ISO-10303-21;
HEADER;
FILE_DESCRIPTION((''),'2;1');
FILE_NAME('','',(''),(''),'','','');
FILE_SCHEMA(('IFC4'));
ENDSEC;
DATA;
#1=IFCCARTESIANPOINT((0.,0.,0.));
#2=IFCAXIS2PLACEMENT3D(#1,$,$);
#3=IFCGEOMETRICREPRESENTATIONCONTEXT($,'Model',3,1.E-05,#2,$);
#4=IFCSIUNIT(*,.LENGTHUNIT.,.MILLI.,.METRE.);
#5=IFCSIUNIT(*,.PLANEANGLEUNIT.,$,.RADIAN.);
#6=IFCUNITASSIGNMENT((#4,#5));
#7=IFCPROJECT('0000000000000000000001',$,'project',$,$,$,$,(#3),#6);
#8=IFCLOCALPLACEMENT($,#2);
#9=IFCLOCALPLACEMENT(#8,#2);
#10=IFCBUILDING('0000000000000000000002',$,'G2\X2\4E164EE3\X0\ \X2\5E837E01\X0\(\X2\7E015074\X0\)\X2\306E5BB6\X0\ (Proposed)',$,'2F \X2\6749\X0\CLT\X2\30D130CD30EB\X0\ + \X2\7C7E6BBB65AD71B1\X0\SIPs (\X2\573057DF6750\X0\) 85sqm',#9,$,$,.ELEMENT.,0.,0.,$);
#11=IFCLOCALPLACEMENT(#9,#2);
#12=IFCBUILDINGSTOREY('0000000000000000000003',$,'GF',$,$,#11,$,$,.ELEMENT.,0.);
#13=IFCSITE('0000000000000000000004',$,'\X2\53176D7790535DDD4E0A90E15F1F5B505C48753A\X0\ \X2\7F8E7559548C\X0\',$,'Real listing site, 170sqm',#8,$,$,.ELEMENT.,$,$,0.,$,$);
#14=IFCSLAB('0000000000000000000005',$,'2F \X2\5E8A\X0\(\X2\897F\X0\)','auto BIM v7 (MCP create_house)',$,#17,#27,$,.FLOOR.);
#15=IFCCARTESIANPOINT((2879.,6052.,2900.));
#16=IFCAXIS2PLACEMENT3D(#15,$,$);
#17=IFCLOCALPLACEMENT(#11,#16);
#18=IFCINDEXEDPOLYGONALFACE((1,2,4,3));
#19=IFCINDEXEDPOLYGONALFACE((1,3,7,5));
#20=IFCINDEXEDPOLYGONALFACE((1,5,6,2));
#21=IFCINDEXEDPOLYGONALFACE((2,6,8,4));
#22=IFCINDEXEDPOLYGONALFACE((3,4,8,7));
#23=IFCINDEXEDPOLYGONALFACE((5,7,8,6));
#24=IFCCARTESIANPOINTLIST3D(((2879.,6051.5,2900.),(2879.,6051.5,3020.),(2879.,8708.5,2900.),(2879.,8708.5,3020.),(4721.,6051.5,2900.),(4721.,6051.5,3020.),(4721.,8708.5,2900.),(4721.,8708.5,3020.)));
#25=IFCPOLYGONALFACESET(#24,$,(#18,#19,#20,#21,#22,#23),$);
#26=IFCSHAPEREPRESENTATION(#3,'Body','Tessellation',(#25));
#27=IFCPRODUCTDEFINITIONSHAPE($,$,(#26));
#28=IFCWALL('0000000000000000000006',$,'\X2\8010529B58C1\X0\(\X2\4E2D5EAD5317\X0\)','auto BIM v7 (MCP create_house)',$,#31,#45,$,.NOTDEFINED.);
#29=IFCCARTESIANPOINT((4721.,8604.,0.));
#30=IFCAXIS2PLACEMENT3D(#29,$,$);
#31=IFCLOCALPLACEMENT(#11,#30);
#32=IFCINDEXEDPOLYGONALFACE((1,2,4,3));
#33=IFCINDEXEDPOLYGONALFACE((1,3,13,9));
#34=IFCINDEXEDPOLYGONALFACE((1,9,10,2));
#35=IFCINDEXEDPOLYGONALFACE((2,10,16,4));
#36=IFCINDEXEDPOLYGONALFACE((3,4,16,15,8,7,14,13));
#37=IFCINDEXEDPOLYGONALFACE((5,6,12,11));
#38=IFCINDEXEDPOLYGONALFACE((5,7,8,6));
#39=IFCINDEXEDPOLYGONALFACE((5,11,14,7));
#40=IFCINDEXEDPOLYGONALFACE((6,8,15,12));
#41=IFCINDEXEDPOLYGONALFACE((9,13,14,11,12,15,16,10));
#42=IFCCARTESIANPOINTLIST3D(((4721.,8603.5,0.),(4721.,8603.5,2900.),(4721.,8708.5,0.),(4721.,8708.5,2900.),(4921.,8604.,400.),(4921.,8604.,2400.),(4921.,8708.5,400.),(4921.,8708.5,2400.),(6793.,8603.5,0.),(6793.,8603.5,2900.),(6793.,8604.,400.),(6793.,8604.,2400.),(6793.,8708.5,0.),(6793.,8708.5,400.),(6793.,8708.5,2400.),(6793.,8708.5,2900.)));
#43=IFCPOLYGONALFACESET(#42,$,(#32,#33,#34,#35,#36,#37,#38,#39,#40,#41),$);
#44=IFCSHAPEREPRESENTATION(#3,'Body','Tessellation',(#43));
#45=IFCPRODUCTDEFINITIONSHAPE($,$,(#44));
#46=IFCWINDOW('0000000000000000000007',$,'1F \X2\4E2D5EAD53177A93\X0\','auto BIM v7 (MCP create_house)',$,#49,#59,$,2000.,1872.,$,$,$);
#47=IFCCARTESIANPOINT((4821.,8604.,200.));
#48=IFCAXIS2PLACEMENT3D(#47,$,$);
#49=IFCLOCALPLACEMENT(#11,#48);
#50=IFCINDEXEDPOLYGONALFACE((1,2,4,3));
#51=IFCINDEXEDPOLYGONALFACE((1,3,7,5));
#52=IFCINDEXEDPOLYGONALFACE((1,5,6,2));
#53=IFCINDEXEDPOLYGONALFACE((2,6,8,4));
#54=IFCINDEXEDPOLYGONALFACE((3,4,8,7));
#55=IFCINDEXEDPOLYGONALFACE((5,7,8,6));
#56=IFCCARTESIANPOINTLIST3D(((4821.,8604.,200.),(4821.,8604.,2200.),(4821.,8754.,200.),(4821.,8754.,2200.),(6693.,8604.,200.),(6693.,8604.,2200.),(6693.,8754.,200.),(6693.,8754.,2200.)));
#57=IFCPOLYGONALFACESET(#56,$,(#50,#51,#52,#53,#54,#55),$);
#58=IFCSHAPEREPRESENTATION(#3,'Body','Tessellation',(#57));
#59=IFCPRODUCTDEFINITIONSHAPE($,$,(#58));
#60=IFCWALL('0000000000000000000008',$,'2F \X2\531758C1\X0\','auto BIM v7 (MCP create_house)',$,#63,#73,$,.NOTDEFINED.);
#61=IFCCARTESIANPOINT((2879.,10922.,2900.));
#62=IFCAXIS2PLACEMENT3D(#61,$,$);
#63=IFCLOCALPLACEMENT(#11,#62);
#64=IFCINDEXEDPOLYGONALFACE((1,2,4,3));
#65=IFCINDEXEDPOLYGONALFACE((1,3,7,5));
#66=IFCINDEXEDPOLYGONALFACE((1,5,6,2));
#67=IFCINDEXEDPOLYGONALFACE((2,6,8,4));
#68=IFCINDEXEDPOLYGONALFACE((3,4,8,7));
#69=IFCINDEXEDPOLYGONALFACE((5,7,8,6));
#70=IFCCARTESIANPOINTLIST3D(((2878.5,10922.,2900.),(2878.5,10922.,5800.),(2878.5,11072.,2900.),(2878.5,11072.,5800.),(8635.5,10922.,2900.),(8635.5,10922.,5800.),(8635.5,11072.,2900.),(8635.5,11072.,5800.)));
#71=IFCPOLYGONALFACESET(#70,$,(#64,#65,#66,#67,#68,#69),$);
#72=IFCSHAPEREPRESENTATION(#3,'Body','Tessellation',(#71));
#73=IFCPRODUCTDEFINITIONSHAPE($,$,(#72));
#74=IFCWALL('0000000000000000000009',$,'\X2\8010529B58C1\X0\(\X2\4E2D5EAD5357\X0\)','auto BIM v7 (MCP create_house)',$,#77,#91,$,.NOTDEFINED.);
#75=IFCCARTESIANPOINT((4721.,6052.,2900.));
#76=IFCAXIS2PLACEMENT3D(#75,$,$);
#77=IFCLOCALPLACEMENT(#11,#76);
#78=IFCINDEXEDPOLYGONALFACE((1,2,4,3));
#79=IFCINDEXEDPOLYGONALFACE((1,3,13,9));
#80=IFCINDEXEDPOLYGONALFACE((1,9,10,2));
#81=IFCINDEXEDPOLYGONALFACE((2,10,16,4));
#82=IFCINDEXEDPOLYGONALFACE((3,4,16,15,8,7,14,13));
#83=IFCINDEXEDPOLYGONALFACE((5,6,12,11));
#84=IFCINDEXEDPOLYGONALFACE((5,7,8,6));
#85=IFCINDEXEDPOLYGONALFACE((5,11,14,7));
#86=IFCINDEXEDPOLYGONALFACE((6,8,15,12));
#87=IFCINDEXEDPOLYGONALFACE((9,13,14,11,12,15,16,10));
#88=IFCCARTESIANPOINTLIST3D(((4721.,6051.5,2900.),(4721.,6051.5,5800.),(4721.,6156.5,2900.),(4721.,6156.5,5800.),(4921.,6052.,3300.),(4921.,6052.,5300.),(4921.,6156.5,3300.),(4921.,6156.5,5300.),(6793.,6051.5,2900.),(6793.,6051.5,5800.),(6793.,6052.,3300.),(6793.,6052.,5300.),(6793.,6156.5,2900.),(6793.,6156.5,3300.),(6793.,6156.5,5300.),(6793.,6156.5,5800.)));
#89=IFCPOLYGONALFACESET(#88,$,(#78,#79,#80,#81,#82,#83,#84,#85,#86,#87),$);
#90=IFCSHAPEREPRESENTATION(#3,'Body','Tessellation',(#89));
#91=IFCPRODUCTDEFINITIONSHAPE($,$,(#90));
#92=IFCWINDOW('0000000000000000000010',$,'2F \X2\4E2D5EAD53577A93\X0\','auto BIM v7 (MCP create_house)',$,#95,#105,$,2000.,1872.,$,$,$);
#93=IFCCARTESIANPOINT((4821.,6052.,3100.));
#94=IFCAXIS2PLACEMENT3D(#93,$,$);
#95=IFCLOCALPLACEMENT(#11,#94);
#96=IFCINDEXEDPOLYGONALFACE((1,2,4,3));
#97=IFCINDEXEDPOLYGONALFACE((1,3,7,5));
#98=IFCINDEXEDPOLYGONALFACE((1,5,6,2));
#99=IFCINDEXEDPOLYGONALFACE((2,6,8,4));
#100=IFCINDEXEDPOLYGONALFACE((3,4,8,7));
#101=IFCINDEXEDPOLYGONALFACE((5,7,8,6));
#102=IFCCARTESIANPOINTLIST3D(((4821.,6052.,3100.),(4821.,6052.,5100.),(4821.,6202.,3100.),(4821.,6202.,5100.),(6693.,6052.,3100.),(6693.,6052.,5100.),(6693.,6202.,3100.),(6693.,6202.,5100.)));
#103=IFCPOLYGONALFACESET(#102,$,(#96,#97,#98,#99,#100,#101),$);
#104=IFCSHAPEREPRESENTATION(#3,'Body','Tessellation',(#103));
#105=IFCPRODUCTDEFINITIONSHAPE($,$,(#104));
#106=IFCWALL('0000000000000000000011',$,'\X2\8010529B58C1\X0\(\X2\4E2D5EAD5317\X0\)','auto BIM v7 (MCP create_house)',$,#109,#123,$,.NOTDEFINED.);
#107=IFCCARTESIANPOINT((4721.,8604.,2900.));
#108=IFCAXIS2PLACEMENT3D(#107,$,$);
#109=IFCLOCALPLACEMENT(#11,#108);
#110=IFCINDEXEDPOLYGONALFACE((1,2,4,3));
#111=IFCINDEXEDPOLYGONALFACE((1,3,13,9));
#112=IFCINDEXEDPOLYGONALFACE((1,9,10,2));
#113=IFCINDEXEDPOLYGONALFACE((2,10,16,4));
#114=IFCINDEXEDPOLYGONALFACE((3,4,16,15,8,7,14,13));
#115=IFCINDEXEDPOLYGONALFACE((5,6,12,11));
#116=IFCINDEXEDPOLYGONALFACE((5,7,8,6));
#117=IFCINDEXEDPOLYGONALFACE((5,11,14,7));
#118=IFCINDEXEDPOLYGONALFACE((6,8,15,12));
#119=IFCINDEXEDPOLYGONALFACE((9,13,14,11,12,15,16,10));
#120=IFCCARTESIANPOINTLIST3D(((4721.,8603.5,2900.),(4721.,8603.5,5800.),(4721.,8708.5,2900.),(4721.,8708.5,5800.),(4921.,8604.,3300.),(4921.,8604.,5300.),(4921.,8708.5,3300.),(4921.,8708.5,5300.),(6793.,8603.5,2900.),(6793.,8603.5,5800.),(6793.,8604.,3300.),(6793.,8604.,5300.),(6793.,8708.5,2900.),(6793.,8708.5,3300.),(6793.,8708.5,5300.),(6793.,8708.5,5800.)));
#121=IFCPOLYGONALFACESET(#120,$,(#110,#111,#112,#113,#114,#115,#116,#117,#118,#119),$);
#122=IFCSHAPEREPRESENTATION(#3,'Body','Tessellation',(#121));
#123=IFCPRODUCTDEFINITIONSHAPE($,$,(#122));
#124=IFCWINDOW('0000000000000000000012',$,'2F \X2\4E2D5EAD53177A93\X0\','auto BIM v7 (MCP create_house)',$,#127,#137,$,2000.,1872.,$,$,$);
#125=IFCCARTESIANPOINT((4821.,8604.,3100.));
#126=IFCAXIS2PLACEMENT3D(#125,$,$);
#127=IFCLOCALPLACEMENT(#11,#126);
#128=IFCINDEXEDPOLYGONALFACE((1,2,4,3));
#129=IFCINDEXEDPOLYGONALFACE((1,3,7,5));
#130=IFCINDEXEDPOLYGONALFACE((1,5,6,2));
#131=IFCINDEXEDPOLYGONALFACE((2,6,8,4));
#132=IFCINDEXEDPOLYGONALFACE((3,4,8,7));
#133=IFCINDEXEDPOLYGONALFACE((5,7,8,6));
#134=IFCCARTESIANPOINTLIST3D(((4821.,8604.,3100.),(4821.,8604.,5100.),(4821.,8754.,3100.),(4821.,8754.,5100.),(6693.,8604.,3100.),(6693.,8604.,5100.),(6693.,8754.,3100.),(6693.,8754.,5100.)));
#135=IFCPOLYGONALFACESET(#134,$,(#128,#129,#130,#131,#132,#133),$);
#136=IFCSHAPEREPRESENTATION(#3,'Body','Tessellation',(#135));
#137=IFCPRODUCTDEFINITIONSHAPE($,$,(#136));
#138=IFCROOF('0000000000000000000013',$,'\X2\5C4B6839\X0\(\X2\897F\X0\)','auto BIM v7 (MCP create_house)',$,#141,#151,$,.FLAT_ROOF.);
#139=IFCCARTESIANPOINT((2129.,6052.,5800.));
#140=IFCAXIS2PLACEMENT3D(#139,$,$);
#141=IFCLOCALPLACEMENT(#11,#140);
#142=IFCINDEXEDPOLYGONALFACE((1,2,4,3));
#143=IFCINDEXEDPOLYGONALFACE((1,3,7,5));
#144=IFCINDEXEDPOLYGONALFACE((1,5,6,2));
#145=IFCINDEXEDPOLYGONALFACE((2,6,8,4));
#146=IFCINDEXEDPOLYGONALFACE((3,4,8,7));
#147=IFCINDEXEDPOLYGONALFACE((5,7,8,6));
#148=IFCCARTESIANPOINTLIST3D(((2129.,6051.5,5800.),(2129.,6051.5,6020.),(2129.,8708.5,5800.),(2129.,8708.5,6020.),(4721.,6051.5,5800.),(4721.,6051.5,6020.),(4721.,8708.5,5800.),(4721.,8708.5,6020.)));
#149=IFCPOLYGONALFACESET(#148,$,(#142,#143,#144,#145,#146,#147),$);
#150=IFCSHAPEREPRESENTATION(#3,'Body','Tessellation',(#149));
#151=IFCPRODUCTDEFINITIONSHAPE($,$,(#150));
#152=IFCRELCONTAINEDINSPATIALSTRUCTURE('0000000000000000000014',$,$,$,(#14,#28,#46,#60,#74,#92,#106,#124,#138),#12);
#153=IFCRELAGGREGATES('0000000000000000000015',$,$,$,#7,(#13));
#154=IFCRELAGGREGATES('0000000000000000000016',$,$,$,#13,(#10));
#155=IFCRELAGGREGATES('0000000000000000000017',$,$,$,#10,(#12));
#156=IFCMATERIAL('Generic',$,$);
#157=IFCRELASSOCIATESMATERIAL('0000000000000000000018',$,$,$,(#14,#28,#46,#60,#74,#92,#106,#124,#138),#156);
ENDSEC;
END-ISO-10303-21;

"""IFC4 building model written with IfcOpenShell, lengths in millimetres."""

from ifc_helpers import new_model, si_unit, frame, frame_2d, origin, place, context, project, spatial, rectangle, extrude, material, element, fill, save


model = new_model("IFC4")

# Units and contexts
model_context = context("Model", 3, precision=1e-05, world=origin())
ifc_project = project(units=[si_unit("LENGTHUNIT", "METRE", prefix="MILLI"), si_unit("PLANEANGLEUNIT", "RADIAN")], contexts=[model_context])

# Site, building, storey
site_placement = place(None, origin())
site = spatial("IfcSite", under=ifc_project, at=site_placement, Name="北海道川上郡弟子屈町 美留和", ObjectType="Real listing site, 170sqm", CompositionType="ELEMENT", RefElevation=0.0)
building_placement = place(site_placement, origin())
building = spatial("IfcBuilding", under=site, at=building_placement, Name="G2世代 広縁(縁側)の家 (Proposed)", ObjectType="2F 杉CLTパネル + 籾殻断熱SIPs (地域材) 85sqm", CompositionType="ELEMENT", ElevationOfRefHeight=0.0, ElevationOfTerrain=0.0)
storey_placement = place(building_placement, origin())
storey = spatial("IfcBuildingStorey", under=building, at=storey_placement, Name="GF", CompositionType="ELEMENT", Elevation=0.0)

# Slab
ifc_material = material(Name="Generic")
slab_1_placement = place(storey_placement, frame((2879.0, 6052.0, 2900.0)))
element("IfcSlab", 1, at=slab_1_placement, inside=storey, material=ifc_material, Name="2F 床(西)", Description="auto BIM v7 (MCP create_house)", PredefinedType="FLOOR", context=model_context, shape_type="SweptSolid", body=[
    extrude(rectangle(XDim=1842.0, YDim=2657.0, at=frame_2d((921.0, 1328.0))), frame((2879.0, 6052.0, 2900.0)), (0.0, 0.0, 1.0), 120.0),
])

# Wall, opening, window
wall_1_placement = place(storey_placement, frame((4721.0, 8604.0, 0.0)))
wall_1 = element("IfcWall", 2, at=wall_1_placement, inside=storey, material=ifc_material, Name="耐力壁(中庭北)", Description="auto BIM v7 (MCP create_house)", PredefinedType="NOTDEFINED", context=model_context, shape_type="SweptSolid", body=[
    extrude(rectangle(XDim=2072.0, YDim=105.0, at=frame_2d((1036.0, 52.0))), frame((4721.0, 8604.0, 0.0)), (0.0, 0.0, 1.0), 2900.0),
])
opening_1_placement = place(storey_placement, frame((4821.0, 8604.0, 200.0)))
opening_1 = element("IfcOpeningElement", 3, at=opening_1_placement, cuts=wall_1, PredefinedType="NOTDEFINED", context=model_context, shape_type="SweptSolid", body=[
    extrude(rectangle(XDim=1872.0, YDim=150.0, at=frame_2d((936.0, 75.0))), frame((4821.0, 8604.0, 200.0)), (0.0, 0.0, 1.0), 2000.0),
])
window_1_placement = place(storey_placement, frame((4821.0, 8604.0, 200.0)))
window_1 = element("IfcWindow", 4, at=window_1_placement, inside=storey, material=ifc_material, Name="1F 中庭北窓", Description="auto BIM v7 (MCP create_house)", OverallHeight=2000.0, OverallWidth=1872.0, context=model_context, shape_type="SweptSolid", body=[
    extrude(rectangle(XDim=1872.0, YDim=150.0, at=frame_2d((936.0, 75.0))), frame((4821.0, 8604.0, 200.0)), (0.0, 0.0, 1.0), 2000.0),
])
fill(opening_1, window_1)

# Wall
wall_2_placement = place(storey_placement, frame((2879.0, 10922.0, 2900.0)))
element("IfcWall", 5, at=wall_2_placement, inside=storey, material=ifc_material, Name="2F 北壁", Description="auto BIM v7 (MCP create_house)", PredefinedType="NOTDEFINED", context=model_context, shape_type="SweptSolid", body=[
    extrude(rectangle(XDim=5757.0, YDim=150.0, at=frame_2d((2878.0, 75.0))), frame((2879.0, 10922.0, 2900.0)), (0.0, 0.0, 1.0), 2900.0),
])

# Walls, openings, windows
wall_3_placement = place(storey_placement, frame((4721.0, 6052.0, 2900.0)))
wall_3 = element("IfcWall", 6, at=wall_3_placement, inside=storey, material=ifc_material, Name="耐力壁(中庭南)", Description="auto BIM v7 (MCP create_house)", PredefinedType="NOTDEFINED", context=model_context, shape_type="SweptSolid", body=[
    extrude(rectangle(XDim=2072.0, YDim=105.0, at=frame_2d((1036.0, 52.0))), frame((4721.0, 6052.0, 2900.0)), (0.0, 0.0, 1.0), 2900.0),
])
opening_2_placement = place(storey_placement, frame((4821.0, 6052.0, 3100.0)))
opening_2 = element("IfcOpeningElement", 7, at=opening_2_placement, cuts=wall_3, PredefinedType="NOTDEFINED", context=model_context, shape_type="SweptSolid", body=[
    extrude(rectangle(XDim=1872.0, YDim=150.0, at=frame_2d((936.0, 75.0))), frame((4821.0, 6052.0, 3100.0)), (0.0, 0.0, 1.0), 2000.0),
])
window_2_placement = place(storey_placement, frame((4821.0, 6052.0, 3100.0)))
window_2 = element("IfcWindow", 8, at=window_2_placement, inside=storey, material=ifc_material, Name="2F 中庭南窓", Description="auto BIM v7 (MCP create_house)", OverallHeight=2000.0, OverallWidth=1872.0, context=model_context, shape_type="SweptSolid", body=[
    extrude(rectangle(XDim=1872.0, YDim=150.0, at=frame_2d((936.0, 75.0))), frame((4821.0, 6052.0, 3100.0)), (0.0, 0.0, 1.0), 2000.0),
])
fill(opening_2, window_2)
wall_4_placement = place(storey_placement, frame((4721.0, 8604.0, 2900.0)))
wall_4 = element("IfcWall", 9, at=wall_4_placement, inside=storey, material=ifc_material, Name="耐力壁(中庭北)", Description="auto BIM v7 (MCP create_house)", PredefinedType="NOTDEFINED", context=model_context, shape_type="SweptSolid", body=[
    extrude(rectangle(XDim=2072.0, YDim=105.0, at=frame_2d((1036.0, 52.0))), frame((4721.0, 8604.0, 2900.0)), (0.0, 0.0, 1.0), 2900.0),
])
opening_3_placement = place(storey_placement, frame((4821.0, 8604.0, 3100.0)))
opening_3 = element("IfcOpeningElement", 10, at=opening_3_placement, cuts=wall_4, PredefinedType="NOTDEFINED", context=model_context, shape_type="SweptSolid", body=[
    extrude(rectangle(XDim=1872.0, YDim=150.0, at=frame_2d((936.0, 75.0))), frame((4821.0, 8604.0, 3100.0)), (0.0, 0.0, 1.0), 2000.0),
])
window_3_placement = place(storey_placement, frame((4821.0, 8604.0, 3100.0)))
window_3 = element("IfcWindow", 11, at=window_3_placement, inside=storey, material=ifc_material, Name="2F 中庭北窓", Description="auto BIM v7 (MCP create_house)", OverallHeight=2000.0, OverallWidth=1872.0, context=model_context, shape_type="SweptSolid", body=[
    extrude(rectangle(XDim=1872.0, YDim=150.0, at=frame_2d((936.0, 75.0))), frame((4821.0, 8604.0, 3100.0)), (0.0, 0.0, 1.0), 2000.0),
])
fill(opening_3, window_3)

# Roof
roof_1_placement = place(storey_placement, frame((2129.0, 6052.0, 5800.0)))
element("IfcRoof", 12, at=roof_1_placement, inside=storey, material=ifc_material, Name="屋根(西)", Description="auto BIM v7 (MCP create_house)", PredefinedType="FLAT_ROOF", context=model_context, shape_type="SweptSolid", body=[
    extrude(rectangle(XDim=2592.0, YDim=2657.0, at=frame_2d((1296.0, 1328.0))), frame((2129.0, 6052.0, 5800.0)), (0.0, 0.0, 1.0), 220.0),
])

save(model, "model.ifc")
